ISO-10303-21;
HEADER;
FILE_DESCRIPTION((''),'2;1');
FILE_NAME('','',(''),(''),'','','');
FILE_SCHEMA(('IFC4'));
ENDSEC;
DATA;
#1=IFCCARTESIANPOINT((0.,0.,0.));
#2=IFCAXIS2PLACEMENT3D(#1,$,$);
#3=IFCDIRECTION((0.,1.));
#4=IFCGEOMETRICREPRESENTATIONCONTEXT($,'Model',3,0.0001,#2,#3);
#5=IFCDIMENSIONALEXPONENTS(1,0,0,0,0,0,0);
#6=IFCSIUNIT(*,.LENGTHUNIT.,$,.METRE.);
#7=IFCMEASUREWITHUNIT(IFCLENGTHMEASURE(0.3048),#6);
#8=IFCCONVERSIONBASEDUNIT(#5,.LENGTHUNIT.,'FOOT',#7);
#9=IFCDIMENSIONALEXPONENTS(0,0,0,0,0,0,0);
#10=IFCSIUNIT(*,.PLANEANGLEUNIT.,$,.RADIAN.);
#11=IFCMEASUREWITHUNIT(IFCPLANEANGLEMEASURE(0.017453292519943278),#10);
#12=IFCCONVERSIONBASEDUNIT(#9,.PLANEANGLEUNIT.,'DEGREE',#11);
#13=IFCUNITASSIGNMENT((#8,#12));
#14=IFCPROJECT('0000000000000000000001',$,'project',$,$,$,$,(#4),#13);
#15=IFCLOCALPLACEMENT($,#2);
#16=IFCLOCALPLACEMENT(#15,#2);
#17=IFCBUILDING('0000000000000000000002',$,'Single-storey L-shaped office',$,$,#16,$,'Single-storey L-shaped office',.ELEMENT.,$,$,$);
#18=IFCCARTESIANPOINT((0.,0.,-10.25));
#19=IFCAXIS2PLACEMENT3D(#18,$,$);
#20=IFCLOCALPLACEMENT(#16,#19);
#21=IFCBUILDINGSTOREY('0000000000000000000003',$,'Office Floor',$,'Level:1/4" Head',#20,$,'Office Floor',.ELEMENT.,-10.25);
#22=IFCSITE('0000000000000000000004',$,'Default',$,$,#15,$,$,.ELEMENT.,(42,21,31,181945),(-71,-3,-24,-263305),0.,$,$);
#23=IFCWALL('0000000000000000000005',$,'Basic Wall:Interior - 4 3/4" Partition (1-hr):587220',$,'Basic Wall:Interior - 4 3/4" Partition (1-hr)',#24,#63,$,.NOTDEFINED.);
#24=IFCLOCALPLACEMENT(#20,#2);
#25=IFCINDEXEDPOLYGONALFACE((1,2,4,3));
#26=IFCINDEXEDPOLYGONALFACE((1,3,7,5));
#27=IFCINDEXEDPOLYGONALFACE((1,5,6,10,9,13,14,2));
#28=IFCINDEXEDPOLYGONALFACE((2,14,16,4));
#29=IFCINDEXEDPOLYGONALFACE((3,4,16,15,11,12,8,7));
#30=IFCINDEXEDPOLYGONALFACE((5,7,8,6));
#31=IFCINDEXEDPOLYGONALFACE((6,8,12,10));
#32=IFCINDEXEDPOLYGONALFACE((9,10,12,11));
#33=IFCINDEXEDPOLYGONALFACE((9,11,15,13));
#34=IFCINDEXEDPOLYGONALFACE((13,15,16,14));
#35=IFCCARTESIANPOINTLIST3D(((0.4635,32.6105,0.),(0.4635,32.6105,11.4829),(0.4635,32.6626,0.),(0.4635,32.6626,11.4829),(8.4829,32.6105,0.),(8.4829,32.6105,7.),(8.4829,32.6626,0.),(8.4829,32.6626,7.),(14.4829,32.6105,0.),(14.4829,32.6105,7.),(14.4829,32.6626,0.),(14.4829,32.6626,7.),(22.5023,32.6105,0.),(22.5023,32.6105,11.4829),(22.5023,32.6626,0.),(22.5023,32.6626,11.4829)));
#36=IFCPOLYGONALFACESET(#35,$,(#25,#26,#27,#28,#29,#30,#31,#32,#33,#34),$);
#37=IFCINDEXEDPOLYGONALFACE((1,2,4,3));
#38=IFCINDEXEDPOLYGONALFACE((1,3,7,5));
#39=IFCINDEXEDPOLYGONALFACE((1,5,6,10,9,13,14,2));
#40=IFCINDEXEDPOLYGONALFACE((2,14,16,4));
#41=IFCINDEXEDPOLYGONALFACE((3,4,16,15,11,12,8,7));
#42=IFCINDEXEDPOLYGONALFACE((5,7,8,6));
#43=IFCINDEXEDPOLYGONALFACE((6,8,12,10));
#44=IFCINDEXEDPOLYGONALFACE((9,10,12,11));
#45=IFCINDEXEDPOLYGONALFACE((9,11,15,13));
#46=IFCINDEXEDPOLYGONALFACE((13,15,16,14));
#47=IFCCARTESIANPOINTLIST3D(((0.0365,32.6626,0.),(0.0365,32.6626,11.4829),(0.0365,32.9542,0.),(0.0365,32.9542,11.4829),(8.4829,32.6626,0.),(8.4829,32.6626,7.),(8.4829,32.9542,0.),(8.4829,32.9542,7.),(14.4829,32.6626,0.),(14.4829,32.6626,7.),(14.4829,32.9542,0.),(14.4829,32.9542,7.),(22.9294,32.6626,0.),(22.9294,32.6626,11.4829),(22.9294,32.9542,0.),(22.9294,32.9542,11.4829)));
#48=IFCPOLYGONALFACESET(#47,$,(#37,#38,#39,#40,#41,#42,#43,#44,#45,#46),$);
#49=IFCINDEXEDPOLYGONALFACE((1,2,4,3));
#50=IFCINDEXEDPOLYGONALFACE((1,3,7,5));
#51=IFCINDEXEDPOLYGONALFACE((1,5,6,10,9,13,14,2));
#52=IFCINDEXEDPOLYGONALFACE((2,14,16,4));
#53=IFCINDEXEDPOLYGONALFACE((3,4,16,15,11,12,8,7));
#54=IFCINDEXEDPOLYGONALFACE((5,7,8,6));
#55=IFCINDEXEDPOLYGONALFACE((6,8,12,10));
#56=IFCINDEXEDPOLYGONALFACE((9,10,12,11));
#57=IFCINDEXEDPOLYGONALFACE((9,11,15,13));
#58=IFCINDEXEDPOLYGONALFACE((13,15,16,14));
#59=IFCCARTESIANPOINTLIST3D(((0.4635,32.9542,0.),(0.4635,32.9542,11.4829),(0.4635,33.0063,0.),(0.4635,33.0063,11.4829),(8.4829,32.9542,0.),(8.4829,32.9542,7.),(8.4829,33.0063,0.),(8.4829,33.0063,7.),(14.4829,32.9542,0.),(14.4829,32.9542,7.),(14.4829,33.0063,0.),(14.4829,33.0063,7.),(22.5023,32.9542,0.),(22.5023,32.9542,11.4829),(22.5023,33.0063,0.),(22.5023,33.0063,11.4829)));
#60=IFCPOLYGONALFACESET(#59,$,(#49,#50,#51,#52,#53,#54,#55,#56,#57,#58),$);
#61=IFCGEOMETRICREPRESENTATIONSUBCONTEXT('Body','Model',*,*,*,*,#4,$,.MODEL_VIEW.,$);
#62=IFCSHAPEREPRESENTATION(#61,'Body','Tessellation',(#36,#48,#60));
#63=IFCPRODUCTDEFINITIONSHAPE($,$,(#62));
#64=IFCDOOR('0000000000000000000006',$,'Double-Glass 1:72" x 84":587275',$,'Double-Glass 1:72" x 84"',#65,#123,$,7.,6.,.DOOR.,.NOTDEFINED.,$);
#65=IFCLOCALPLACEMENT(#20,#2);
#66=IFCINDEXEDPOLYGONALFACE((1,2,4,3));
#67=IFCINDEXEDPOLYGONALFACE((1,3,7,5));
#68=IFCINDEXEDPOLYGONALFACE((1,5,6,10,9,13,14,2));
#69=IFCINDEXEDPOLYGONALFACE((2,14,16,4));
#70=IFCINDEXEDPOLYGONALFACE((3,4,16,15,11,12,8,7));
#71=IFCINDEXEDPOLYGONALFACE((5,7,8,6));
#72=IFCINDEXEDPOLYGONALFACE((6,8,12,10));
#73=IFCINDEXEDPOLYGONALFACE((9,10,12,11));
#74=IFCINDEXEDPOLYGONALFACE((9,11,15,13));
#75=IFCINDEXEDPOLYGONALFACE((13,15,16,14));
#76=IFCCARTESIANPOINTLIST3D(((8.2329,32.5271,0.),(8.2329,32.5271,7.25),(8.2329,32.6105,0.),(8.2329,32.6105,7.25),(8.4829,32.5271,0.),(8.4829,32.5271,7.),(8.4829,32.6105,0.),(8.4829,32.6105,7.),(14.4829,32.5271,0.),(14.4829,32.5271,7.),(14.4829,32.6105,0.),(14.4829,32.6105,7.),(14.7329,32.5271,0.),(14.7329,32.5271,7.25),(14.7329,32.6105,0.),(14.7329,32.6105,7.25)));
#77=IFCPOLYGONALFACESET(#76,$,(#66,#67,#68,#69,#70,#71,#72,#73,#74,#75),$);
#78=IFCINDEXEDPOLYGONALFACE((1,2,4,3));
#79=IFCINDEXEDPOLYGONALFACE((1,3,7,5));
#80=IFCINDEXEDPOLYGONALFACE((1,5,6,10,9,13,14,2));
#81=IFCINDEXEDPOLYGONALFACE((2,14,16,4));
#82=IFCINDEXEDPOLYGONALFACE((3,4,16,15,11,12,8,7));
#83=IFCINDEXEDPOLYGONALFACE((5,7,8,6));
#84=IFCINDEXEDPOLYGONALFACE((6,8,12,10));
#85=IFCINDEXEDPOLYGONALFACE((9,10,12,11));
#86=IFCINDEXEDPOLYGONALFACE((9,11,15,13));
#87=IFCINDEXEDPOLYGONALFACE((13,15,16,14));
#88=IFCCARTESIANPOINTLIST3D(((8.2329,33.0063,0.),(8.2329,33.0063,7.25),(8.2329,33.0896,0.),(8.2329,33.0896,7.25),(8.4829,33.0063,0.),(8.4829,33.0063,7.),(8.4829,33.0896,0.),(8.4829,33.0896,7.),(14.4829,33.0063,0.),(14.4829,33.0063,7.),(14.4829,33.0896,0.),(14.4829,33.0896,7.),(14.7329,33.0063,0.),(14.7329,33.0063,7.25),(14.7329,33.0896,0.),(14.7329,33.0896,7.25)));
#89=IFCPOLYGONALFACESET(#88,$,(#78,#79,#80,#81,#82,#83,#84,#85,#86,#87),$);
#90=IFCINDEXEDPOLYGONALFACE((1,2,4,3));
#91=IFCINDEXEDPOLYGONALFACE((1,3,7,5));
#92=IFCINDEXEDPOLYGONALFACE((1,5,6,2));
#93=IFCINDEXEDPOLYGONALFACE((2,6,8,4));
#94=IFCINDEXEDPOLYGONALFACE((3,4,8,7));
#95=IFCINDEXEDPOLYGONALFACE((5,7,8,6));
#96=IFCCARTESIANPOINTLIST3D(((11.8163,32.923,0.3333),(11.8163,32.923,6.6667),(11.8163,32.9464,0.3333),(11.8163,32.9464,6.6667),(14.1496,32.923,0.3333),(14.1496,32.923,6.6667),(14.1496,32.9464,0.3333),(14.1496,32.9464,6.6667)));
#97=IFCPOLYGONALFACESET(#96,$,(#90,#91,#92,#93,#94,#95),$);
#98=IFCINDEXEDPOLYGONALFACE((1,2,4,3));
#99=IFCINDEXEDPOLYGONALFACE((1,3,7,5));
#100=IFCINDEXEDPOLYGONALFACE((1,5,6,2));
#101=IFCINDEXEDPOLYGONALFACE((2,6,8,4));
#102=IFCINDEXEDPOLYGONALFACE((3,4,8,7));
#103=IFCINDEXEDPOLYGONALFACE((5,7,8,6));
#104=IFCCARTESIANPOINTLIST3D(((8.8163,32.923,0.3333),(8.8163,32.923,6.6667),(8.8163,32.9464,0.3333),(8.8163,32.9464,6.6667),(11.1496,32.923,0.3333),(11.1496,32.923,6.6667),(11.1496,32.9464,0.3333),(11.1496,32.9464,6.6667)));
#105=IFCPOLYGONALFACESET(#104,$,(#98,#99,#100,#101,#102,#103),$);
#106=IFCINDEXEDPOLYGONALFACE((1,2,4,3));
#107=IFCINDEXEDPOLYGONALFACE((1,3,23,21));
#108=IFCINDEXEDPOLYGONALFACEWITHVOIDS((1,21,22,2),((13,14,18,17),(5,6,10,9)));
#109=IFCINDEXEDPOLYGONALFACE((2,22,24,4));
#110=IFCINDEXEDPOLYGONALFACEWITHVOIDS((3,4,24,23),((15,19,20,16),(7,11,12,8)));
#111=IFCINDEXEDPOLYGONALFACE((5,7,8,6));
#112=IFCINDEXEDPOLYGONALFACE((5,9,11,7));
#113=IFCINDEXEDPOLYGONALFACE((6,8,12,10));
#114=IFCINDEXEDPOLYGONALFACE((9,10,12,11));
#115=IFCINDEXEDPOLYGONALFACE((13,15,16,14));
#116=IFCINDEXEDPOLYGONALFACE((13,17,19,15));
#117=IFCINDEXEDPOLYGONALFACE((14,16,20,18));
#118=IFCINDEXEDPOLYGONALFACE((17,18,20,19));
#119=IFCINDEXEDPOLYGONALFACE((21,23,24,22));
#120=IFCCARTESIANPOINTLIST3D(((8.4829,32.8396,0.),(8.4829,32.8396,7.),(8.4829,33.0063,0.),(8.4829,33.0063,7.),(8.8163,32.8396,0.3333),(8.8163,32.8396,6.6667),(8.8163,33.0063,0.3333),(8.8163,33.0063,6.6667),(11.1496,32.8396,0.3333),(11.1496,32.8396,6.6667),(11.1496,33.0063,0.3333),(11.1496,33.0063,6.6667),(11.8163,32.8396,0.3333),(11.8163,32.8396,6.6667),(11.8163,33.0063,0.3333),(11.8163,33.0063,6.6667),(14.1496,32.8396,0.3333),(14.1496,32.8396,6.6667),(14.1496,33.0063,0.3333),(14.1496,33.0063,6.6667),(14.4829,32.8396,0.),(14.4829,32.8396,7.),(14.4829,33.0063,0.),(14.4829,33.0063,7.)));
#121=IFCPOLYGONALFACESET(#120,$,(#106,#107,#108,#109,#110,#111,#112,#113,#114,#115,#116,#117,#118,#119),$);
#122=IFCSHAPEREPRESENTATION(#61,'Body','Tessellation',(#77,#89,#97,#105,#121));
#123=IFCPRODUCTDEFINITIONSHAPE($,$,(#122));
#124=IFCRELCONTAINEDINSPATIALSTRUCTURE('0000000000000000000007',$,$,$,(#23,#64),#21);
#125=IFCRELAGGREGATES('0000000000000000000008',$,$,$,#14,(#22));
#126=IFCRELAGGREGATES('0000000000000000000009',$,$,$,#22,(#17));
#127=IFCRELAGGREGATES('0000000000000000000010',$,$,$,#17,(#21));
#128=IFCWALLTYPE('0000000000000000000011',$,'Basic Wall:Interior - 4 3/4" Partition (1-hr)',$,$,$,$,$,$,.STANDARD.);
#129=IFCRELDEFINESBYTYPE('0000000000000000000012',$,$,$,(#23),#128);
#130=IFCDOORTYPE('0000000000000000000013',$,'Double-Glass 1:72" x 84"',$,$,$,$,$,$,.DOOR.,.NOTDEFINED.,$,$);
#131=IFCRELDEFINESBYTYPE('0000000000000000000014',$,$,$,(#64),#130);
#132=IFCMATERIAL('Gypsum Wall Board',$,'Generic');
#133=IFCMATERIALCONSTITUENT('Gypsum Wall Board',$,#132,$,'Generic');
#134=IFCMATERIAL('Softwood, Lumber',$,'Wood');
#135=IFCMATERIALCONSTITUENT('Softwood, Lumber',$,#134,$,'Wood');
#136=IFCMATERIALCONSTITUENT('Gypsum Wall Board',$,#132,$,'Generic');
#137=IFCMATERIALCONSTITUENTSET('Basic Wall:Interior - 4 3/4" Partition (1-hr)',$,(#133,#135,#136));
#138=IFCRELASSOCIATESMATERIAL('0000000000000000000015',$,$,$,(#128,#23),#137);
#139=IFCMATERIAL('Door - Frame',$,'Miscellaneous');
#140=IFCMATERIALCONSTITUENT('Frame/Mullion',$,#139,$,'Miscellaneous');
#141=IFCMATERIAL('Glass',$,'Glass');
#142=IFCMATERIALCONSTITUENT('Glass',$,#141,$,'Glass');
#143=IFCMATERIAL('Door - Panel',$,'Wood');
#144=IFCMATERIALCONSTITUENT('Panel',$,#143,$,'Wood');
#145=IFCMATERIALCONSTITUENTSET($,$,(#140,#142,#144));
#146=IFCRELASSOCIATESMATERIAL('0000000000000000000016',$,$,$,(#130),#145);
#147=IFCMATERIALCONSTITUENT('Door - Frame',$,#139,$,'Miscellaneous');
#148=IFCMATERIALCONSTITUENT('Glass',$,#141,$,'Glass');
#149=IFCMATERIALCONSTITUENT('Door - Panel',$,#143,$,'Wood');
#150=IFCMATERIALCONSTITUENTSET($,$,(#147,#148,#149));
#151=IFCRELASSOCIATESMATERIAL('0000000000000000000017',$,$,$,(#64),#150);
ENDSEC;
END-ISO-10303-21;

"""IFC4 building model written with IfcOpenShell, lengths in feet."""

from ifc_helpers import new_model, entity, si_unit, converted_unit, direction, frame, origin, place, context, subcontext, project, spatial, indexed_curve, outline, extrude, source, transform, mapped, material, constituent, constituent_set, type_object, type_shapes, element, fill, save


model = new_model("IFC4")

# Units and contexts
model_context = context("Model", 3, precision=0.0001, world=origin(), true_north=direction((0.0, 1.0)))
body_context = subcontext(model_context, "Body", "Model", "MODEL_VIEW")
ifc_project = project(units=[converted_unit("LENGTHUNIT", "FOOT", entity("IfcLengthMeasure", 0.3048), si_unit("LENGTHUNIT", "METRE"), dimensions=[1, 0, 0, 0, 0, 0, 0]), converted_unit("PLANEANGLEUNIT", "DEGREE", entity("IfcPlaneAngleMeasure", 0.017453292519943278), si_unit("PLANEANGLEUNIT", "RADIAN"), dimensions=[0, 0, 0, 0, 0, 0, 0])], contexts=[model_context])

# Site, building, storey
site_placement = place(None, origin())
site = spatial("IfcSite", under=ifc_project, at=site_placement, Name="Default", CompositionType="ELEMENT", RefLatitude=(42, 21, 31, 181945), RefLongitude=(-71, -3, -24, -263305), RefElevation=0.0)
building_placement = place(site_placement, origin())
building = spatial("IfcBuilding", under=site, at=building_placement, Name="Single-storey L-shaped office", LongName="Single-storey L-shaped office", CompositionType="ELEMENT")
storey_placement = place(building_placement, frame((0.0, 0.0, -10.25)))
storey = spatial("IfcBuildingStorey", under=building, at=storey_placement, Name="Office Floor", ObjectType="Level:1/4\" Head", LongName="Office Floor", CompositionType="ELEMENT", Elevation=-10.25)

# Shared definitions
ifc_material_1 = material(Name="Softwood, Lumber", Category="Wood")
ifc_material_2 = material(Name="Gypsum Wall Board", Category="Generic")
ifc_material_3 = material(Name="Door - Frame", Category="Miscellaneous")
ifc_material_4 = material(Name="Glass", Category="Glass")
ifc_material_5 = material(Name="Door - Panel", Category="Wood")

# Wall, opening, door
ifc_constituent_1 = constituent(ifc_material_2, Name="Gypsum Wall Board", Category="Generic")
ifc_constituent_2 = constituent(ifc_material_1, Name="Softwood, Lumber", Category="Wood")
ifc_constituent_3 = constituent(ifc_material_2, Name="Gypsum Wall Board", Category="Generic")
ifc_constituent_set_1 = constituent_set(constituents=[ifc_constituent_1, ifc_constituent_2, ifc_constituent_3], Name="Basic Wall:Interior - 4 3/4\" Partition (1-hr)")
wall_type_1 = type_object("IfcWallType", Name="Basic Wall:Interior - 4 3/4\" Partition (1-hr)", PredefinedType="STANDARD", material=ifc_constituent_set_1)
ifc_constituent_4 = constituent(ifc_material_3, Name="Frame/Mullion", Category="Miscellaneous")
ifc_constituent_5 = constituent(ifc_material_4, Name="Glass", Category="Glass")
ifc_constituent_6 = constituent(ifc_material_5, Name="Panel", Category="Wood")
ifc_constituent_set_2 = constituent_set(constituents=[ifc_constituent_4, ifc_constituent_5, ifc_constituent_6])
door_type_1 = type_object("IfcDoorType", Name="Double-Glass 1:72\" x 84\"", OperationType="NOTDEFINED", PredefinedType="DOOR", material=ifc_constituent_set_2)
shared_shape_1 = source(origin(), body_context, "Body", "SweptSolid", [
    extrude(outline(indexed_curve([(-3.25, -3.5625), (-3.0, -3.5625), (-3.0, 3.4375), (3.0, 3.4375), (3.0, -3.5625), (3.25, -3.5625), (3.25, 3.6875), (-3.25, 3.6875), (-3.25, -3.5625)], self_intersect=False)), frame((3.0, -0.0833, 3.5625), z_axis=(0.0, 1.0, 0.0), x_axis=(-1.0, 0.0, 0.0)), (0.0, 0.0, 1.0), 0.0833),
    extrude(outline(indexed_curve([(-3.0, -3.4375), (-3.0, 3.5625), (-3.25, 3.5625), (-3.25, -3.6875), (3.25, -3.6875), (3.25, 3.5625), (3.0, 3.5625), (3.0, -3.4375), (-3.0, -3.4375)], self_intersect=False)), frame((3.0, 0.3958, 3.5625), z_axis=(0.0, -1.0, 0.0), x_axis=(-1.0, 0.0, 0.0)), (0.0, 0.0, -1.0), 0.0833),
    extrude(outline(indexed_curve([(-0.0117, -1.1667), (0.0117, -1.1667), (0.0117, 1.1667), (-0.0117, 1.1667), (-0.0117, -1.1667)], self_intersect=False)), frame((4.5, 0.3242, 0.3333), z_axis=(0.0, 0.0, 1.0), x_axis=(0.0, 1.0, 0.0)), (0.0, 0.0, 1.0), 6.3333),
    extrude(outline(indexed_curve([(-0.0117, -1.1667), (0.0117, -1.1667), (0.0117, 1.1667), (-0.0117, 1.1667), (-0.0117, -1.1667)], self_intersect=False)), frame((1.5, 0.3242, 0.3333), z_axis=(0.0, 0.0, 1.0), x_axis=(0.0, 1.0, 0.0)), (0.0, 0.0, 1.0), 6.3333),
    extrude(outline(indexed_curve([(-3.5, -3.0), (3.5, -3.0), (3.5, 3.0), (-3.5, 3.0), (-3.5, -3.0)], self_intersect=False), holes=[indexed_curve([(-3.1667, 0.3333), (-3.1667, 2.6667), (3.1667, 2.6667), (3.1667, 0.3333), (-3.1667, 0.3333)], self_intersect=False), indexed_curve([(-3.1667, -2.6667), (-3.1667, -0.3333), (3.1667, -0.3333), (3.1667, -2.6667), (-3.1667, -2.6667)], self_intersect=False)]), frame((3.0, 0.2292, 3.5), z_axis=(0.0, 1.0, 0.0), x_axis=(0.0, 0.0, -1.0)), (0.0, 0.0, 1.0), 0.1667),
])
type_shapes(door_type_1, [shared_shape_1])
wall_1_placement = place(storey_placement, frame((0.4635, 32.8084, 0.0)))
wall_1 = element("IfcWall", 1, at=wall_1_placement, inside=storey, type_object=wall_type_1, material=ifc_constituent_set_1, Name="Basic Wall:Interior - 4 3/4\" Partition (1-hr):587220", ObjectType="Basic Wall:Interior - 4 3/4\" Partition (1-hr)", PredefinedType="NOTDEFINED", context=body_context, shape_type="SweptSolid", body=[
    extrude(outline(indexed_curve([(-3.0, -2.3793), (-3.0, 4.6207), (-11.0194, 4.6207), (-11.0194, -6.8622), (11.0194, -6.8622), (11.0194, 4.6207), (3.0, 4.6207), (3.0, -2.3793), (-3.0, -2.3793)], self_intersect=False)), frame((11.0194, -0.1979, 4.6207), z_axis=(0.0, -1.0, 0.0), x_axis=(-1.0, 0.0, 0.0)), (0.0, 0.0, -1.0), 0.0521),
    extrude(outline(indexed_curve([(-4.6207, -11.4465), (6.8622, -11.4465), (6.8622, 11.4465), (-4.6207, 11.4465), (-4.6207, 3.0), (2.3793, 3.0), (2.3793, -3.0), (-4.6207, -3.0), (-4.6207, -11.4465)], self_intersect=False)), frame((11.0194, -0.1458, 4.6207), z_axis=(0.0, 1.0, 0.0), x_axis=(0.0, 0.0, 1.0)), (0.0, 0.0, 1.0), 0.2917),
    extrude(outline(indexed_curve([(-4.6207, -11.0194), (6.8622, -11.0194), (6.8622, 11.0194), (-4.6207, 11.0194), (-4.6207, 3.0), (2.3793, 3.0), (2.3793, -3.0), (-4.6207, -3.0), (-4.6207, -11.0194)], self_intersect=False)), frame((11.0194, 0.1458, 4.6207), z_axis=(0.0, 1.0, 0.0), x_axis=(0.0, 0.0, 1.0)), (0.0, 0.0, 1.0), 0.0521),
])
opening_1_placement = place(wall_1_placement, frame((8.0194, -0.1979, 0.0)))
opening_1 = element("IfcOpeningElement", 2, at=opening_1_placement, cuts=wall_1, PredefinedType="OPENING", context=body_context, shape_type="SweptSolid", body=[
    extrude(outline(indexed_curve([(0.0, 0.0), (7.0, 0.0), (7.0, 6.0), (0.0, 6.0), (0.0, 0.0)], self_intersect=False)), frame((0.0, 0.0, 0.0), z_axis=(0.0, 1.0, 0.0), x_axis=(0.0, 0.0, 1.0)), (0.0, 0.0, 1.0), 0.3958),
])
ifc_constituent_7 = constituent(ifc_material_3, Name="Door - Frame", Category="Miscellaneous")
ifc_constituent_8 = constituent(ifc_material_4, Name="Glass", Category="Glass")
ifc_constituent_9 = constituent(ifc_material_5, Name="Door - Panel", Category="Wood")
ifc_constituent_set_3 = constituent_set(constituents=[ifc_constituent_7, ifc_constituent_8, ifc_constituent_9])
door_1_placement = place(opening_1_placement, origin())
door_1 = element("IfcDoor", 3, at=door_1_placement, inside=storey, type_object=door_type_1, material=ifc_constituent_set_3, Name="Double-Glass 1:72\" x 84\":587275", ObjectType="Double-Glass 1:72\" x 84\"", OperationType="NOTDEFINED", OverallHeight=7.0, OverallWidth=6.0, PredefinedType="DOOR", context=body_context, shape_type="MappedRepresentation", body=[
    mapped(shared_shape_1, transform((0.0, 0.0, 0.0), scale=1.0)),
])
fill(opening_1, door_1)

save(model, "model.ifc")
